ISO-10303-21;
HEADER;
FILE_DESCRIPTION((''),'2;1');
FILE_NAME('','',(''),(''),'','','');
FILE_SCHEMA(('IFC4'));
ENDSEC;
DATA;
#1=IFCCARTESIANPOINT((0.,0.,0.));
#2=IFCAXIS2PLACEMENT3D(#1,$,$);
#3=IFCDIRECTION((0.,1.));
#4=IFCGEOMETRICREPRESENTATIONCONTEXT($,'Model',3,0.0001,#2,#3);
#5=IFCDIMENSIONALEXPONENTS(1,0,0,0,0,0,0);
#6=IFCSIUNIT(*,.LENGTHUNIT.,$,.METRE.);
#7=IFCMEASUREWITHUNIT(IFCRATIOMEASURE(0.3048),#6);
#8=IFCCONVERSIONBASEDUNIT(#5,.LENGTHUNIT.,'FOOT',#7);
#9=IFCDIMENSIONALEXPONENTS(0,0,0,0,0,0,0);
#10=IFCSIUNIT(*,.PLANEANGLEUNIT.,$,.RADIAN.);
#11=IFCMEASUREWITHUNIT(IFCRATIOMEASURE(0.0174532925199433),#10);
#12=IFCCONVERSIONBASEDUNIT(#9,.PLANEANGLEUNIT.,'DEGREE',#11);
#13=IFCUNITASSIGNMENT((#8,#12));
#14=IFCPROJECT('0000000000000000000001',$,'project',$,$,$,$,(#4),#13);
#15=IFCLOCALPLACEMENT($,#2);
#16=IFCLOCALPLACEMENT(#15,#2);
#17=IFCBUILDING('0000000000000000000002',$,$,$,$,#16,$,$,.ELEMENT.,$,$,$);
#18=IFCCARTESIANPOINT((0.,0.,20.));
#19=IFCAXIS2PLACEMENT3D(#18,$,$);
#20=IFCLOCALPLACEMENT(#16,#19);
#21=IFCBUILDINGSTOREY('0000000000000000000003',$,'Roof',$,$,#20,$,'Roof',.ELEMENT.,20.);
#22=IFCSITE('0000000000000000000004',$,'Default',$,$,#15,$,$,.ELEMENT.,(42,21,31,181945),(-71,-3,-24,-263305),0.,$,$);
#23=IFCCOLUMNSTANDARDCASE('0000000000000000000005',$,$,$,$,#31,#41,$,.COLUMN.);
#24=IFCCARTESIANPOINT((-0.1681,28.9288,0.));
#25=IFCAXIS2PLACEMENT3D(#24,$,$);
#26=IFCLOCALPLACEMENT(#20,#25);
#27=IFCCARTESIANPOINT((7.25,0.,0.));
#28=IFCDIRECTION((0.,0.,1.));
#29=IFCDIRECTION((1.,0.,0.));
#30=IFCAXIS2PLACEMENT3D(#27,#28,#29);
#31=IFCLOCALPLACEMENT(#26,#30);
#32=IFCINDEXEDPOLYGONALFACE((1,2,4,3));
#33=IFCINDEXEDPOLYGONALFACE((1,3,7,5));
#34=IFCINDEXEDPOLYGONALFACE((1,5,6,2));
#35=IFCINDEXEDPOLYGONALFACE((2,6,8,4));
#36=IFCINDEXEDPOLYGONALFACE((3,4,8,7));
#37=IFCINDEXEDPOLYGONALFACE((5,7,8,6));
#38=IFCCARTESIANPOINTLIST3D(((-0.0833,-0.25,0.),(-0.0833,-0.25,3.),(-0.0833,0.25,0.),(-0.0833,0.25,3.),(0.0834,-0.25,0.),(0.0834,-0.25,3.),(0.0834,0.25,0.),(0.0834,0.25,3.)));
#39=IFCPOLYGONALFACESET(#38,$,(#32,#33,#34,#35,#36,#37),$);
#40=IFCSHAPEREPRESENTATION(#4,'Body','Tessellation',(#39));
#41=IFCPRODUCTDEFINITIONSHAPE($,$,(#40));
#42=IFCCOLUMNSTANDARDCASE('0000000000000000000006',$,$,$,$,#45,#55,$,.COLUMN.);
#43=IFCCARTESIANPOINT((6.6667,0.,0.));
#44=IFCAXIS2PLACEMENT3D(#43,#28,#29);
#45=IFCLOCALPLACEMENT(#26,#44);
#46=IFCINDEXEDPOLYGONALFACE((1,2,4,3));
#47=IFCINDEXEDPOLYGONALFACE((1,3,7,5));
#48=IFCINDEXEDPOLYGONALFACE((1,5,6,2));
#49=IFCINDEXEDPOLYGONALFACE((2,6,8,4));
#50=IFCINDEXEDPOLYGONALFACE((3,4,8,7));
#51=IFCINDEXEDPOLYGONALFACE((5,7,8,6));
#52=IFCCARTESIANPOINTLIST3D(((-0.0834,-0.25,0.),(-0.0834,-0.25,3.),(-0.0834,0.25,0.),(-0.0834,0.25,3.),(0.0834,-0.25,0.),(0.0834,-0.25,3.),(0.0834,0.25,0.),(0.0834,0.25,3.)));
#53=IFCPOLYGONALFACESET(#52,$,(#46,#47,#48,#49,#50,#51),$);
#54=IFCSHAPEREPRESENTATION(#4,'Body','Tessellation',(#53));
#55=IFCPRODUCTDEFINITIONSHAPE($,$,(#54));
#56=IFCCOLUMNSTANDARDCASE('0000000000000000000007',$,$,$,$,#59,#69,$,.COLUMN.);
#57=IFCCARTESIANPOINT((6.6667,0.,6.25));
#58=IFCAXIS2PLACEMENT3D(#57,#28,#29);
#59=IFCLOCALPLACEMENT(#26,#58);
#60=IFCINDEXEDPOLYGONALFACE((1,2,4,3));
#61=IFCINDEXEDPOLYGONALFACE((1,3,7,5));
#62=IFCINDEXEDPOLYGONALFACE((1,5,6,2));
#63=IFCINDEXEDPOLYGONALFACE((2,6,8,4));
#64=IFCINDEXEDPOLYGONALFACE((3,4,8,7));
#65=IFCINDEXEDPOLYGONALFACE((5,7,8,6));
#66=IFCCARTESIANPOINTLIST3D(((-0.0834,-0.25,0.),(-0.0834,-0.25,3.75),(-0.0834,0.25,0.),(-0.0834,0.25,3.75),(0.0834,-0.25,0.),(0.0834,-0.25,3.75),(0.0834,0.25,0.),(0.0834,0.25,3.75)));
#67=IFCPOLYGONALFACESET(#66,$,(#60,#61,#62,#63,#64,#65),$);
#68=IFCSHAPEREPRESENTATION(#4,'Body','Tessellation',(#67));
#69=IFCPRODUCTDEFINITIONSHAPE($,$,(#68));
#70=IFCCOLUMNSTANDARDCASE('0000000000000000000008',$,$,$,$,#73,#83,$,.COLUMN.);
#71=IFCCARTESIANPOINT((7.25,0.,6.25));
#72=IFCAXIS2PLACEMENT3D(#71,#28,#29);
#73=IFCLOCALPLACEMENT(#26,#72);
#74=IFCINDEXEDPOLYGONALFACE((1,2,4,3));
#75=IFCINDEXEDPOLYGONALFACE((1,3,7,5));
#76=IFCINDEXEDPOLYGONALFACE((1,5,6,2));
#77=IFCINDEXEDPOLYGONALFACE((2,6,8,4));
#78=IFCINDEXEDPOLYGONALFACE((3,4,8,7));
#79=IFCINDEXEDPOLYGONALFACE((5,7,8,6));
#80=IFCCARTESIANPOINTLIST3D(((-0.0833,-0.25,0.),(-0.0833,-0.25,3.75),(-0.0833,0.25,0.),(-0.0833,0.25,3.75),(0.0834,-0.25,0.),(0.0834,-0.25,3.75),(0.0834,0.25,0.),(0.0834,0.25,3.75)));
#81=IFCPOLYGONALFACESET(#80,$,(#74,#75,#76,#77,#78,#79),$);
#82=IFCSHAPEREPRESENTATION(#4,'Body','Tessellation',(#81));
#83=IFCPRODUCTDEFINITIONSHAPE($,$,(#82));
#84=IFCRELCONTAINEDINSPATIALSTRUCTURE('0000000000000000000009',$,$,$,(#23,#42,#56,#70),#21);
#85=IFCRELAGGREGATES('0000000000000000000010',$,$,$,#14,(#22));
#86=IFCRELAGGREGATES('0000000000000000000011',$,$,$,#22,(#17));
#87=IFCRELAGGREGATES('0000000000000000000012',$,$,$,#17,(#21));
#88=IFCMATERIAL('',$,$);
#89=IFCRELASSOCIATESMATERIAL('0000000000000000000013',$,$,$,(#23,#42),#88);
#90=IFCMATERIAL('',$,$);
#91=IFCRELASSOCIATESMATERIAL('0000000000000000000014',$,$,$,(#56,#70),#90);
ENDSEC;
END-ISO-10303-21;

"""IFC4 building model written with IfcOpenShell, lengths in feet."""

from ifc_helpers import new_model, entity, si_unit, converted_unit, direction, frame, origin, place, context, project, spatial, rectangle, extrude, material, element, save


model = new_model("IFC4")

# Units and contexts
model_context = context("Model", 3, precision=0.0001, world=origin(), true_north=direction((0.0, 1.0)))
ifc_project = project(units=[converted_unit("LENGTHUNIT", "FOOT", entity("IfcRatioMeasure", 0.3048), si_unit("LENGTHUNIT", "METRE"), dimensions=[1, 0, 0, 0, 0, 0, 0]), converted_unit("PLANEANGLEUNIT", "DEGREE", entity("IfcRatioMeasure", 0.0174532925199433), si_unit("PLANEANGLEUNIT", "RADIAN"), dimensions=[0, 0, 0, 0, 0, 0, 0])], contexts=[model_context])

# Site, building, storey
site_placement = place(None, origin())
site = spatial("IfcSite", under=ifc_project, at=site_placement, Name="Default", CompositionType="ELEMENT", RefLatitude=(42, 21, 31, 181945), RefLongitude=(-71, -3, -24, -263305), RefElevation=0.0)
building_placement = place(site_placement, origin())
building = spatial("IfcBuilding", under=site, at=building_placement, CompositionType="ELEMENT")
storey_placement = place(building_placement, frame((0.0, 0.0, 20.0)))
storey = spatial("IfcBuildingStorey", under=building, at=storey_placement, Name="Roof", LongName="Roof", CompositionType="ELEMENT", Elevation=20.0)

# Columns
placement = place(storey_placement, frame((-0.1681, 28.9288, 0.0)))
ifc_material_1 = material(Name="")
for number, where, z_axis, x_axis in (
    (1, (7.25, 0.0, 0.0), (0.0, 0.0, 1.0), (1.0, 0.0, 0.0)),
    (2, (6.6667, 0.0, 0.0), (0.0, 0.0, 1.0), (1.0, 0.0, 0.0)),
):
    element("IfcColumnStandardCase", number, at=place(placement, frame(where, z_axis=z_axis, x_axis=x_axis)), inside=storey, material=ifc_material_1, PredefinedType="COLUMN", context=model_context, shape_type="SweptSolid", body=[
        extrude(rectangle(XDim=0.1667, YDim=0.5), origin(), (0.0, 0.0, 1.0), 3.0),
    ])
ifc_material_2 = material(Name="")
for number, where, z_axis, x_axis in (
    (3, (6.6667, 0.0, 6.25), (0.0, 0.0, 1.0), (1.0, 0.0, 0.0)),
    (4, (7.25, 0.0, 6.25), (0.0, 0.0, 1.0), (1.0, 0.0, 0.0)),
):
    element("IfcColumnStandardCase", number, at=place(placement, frame(where, z_axis=z_axis, x_axis=x_axis)), inside=storey, material=ifc_material_2, PredefinedType="COLUMN", context=model_context, shape_type="SweptSolid", body=[
        extrude(rectangle(XDim=0.1667, YDim=0.5), origin(), (0.0, 0.0, 1.0), 3.75),
    ])

save(model, "model.ifc")
